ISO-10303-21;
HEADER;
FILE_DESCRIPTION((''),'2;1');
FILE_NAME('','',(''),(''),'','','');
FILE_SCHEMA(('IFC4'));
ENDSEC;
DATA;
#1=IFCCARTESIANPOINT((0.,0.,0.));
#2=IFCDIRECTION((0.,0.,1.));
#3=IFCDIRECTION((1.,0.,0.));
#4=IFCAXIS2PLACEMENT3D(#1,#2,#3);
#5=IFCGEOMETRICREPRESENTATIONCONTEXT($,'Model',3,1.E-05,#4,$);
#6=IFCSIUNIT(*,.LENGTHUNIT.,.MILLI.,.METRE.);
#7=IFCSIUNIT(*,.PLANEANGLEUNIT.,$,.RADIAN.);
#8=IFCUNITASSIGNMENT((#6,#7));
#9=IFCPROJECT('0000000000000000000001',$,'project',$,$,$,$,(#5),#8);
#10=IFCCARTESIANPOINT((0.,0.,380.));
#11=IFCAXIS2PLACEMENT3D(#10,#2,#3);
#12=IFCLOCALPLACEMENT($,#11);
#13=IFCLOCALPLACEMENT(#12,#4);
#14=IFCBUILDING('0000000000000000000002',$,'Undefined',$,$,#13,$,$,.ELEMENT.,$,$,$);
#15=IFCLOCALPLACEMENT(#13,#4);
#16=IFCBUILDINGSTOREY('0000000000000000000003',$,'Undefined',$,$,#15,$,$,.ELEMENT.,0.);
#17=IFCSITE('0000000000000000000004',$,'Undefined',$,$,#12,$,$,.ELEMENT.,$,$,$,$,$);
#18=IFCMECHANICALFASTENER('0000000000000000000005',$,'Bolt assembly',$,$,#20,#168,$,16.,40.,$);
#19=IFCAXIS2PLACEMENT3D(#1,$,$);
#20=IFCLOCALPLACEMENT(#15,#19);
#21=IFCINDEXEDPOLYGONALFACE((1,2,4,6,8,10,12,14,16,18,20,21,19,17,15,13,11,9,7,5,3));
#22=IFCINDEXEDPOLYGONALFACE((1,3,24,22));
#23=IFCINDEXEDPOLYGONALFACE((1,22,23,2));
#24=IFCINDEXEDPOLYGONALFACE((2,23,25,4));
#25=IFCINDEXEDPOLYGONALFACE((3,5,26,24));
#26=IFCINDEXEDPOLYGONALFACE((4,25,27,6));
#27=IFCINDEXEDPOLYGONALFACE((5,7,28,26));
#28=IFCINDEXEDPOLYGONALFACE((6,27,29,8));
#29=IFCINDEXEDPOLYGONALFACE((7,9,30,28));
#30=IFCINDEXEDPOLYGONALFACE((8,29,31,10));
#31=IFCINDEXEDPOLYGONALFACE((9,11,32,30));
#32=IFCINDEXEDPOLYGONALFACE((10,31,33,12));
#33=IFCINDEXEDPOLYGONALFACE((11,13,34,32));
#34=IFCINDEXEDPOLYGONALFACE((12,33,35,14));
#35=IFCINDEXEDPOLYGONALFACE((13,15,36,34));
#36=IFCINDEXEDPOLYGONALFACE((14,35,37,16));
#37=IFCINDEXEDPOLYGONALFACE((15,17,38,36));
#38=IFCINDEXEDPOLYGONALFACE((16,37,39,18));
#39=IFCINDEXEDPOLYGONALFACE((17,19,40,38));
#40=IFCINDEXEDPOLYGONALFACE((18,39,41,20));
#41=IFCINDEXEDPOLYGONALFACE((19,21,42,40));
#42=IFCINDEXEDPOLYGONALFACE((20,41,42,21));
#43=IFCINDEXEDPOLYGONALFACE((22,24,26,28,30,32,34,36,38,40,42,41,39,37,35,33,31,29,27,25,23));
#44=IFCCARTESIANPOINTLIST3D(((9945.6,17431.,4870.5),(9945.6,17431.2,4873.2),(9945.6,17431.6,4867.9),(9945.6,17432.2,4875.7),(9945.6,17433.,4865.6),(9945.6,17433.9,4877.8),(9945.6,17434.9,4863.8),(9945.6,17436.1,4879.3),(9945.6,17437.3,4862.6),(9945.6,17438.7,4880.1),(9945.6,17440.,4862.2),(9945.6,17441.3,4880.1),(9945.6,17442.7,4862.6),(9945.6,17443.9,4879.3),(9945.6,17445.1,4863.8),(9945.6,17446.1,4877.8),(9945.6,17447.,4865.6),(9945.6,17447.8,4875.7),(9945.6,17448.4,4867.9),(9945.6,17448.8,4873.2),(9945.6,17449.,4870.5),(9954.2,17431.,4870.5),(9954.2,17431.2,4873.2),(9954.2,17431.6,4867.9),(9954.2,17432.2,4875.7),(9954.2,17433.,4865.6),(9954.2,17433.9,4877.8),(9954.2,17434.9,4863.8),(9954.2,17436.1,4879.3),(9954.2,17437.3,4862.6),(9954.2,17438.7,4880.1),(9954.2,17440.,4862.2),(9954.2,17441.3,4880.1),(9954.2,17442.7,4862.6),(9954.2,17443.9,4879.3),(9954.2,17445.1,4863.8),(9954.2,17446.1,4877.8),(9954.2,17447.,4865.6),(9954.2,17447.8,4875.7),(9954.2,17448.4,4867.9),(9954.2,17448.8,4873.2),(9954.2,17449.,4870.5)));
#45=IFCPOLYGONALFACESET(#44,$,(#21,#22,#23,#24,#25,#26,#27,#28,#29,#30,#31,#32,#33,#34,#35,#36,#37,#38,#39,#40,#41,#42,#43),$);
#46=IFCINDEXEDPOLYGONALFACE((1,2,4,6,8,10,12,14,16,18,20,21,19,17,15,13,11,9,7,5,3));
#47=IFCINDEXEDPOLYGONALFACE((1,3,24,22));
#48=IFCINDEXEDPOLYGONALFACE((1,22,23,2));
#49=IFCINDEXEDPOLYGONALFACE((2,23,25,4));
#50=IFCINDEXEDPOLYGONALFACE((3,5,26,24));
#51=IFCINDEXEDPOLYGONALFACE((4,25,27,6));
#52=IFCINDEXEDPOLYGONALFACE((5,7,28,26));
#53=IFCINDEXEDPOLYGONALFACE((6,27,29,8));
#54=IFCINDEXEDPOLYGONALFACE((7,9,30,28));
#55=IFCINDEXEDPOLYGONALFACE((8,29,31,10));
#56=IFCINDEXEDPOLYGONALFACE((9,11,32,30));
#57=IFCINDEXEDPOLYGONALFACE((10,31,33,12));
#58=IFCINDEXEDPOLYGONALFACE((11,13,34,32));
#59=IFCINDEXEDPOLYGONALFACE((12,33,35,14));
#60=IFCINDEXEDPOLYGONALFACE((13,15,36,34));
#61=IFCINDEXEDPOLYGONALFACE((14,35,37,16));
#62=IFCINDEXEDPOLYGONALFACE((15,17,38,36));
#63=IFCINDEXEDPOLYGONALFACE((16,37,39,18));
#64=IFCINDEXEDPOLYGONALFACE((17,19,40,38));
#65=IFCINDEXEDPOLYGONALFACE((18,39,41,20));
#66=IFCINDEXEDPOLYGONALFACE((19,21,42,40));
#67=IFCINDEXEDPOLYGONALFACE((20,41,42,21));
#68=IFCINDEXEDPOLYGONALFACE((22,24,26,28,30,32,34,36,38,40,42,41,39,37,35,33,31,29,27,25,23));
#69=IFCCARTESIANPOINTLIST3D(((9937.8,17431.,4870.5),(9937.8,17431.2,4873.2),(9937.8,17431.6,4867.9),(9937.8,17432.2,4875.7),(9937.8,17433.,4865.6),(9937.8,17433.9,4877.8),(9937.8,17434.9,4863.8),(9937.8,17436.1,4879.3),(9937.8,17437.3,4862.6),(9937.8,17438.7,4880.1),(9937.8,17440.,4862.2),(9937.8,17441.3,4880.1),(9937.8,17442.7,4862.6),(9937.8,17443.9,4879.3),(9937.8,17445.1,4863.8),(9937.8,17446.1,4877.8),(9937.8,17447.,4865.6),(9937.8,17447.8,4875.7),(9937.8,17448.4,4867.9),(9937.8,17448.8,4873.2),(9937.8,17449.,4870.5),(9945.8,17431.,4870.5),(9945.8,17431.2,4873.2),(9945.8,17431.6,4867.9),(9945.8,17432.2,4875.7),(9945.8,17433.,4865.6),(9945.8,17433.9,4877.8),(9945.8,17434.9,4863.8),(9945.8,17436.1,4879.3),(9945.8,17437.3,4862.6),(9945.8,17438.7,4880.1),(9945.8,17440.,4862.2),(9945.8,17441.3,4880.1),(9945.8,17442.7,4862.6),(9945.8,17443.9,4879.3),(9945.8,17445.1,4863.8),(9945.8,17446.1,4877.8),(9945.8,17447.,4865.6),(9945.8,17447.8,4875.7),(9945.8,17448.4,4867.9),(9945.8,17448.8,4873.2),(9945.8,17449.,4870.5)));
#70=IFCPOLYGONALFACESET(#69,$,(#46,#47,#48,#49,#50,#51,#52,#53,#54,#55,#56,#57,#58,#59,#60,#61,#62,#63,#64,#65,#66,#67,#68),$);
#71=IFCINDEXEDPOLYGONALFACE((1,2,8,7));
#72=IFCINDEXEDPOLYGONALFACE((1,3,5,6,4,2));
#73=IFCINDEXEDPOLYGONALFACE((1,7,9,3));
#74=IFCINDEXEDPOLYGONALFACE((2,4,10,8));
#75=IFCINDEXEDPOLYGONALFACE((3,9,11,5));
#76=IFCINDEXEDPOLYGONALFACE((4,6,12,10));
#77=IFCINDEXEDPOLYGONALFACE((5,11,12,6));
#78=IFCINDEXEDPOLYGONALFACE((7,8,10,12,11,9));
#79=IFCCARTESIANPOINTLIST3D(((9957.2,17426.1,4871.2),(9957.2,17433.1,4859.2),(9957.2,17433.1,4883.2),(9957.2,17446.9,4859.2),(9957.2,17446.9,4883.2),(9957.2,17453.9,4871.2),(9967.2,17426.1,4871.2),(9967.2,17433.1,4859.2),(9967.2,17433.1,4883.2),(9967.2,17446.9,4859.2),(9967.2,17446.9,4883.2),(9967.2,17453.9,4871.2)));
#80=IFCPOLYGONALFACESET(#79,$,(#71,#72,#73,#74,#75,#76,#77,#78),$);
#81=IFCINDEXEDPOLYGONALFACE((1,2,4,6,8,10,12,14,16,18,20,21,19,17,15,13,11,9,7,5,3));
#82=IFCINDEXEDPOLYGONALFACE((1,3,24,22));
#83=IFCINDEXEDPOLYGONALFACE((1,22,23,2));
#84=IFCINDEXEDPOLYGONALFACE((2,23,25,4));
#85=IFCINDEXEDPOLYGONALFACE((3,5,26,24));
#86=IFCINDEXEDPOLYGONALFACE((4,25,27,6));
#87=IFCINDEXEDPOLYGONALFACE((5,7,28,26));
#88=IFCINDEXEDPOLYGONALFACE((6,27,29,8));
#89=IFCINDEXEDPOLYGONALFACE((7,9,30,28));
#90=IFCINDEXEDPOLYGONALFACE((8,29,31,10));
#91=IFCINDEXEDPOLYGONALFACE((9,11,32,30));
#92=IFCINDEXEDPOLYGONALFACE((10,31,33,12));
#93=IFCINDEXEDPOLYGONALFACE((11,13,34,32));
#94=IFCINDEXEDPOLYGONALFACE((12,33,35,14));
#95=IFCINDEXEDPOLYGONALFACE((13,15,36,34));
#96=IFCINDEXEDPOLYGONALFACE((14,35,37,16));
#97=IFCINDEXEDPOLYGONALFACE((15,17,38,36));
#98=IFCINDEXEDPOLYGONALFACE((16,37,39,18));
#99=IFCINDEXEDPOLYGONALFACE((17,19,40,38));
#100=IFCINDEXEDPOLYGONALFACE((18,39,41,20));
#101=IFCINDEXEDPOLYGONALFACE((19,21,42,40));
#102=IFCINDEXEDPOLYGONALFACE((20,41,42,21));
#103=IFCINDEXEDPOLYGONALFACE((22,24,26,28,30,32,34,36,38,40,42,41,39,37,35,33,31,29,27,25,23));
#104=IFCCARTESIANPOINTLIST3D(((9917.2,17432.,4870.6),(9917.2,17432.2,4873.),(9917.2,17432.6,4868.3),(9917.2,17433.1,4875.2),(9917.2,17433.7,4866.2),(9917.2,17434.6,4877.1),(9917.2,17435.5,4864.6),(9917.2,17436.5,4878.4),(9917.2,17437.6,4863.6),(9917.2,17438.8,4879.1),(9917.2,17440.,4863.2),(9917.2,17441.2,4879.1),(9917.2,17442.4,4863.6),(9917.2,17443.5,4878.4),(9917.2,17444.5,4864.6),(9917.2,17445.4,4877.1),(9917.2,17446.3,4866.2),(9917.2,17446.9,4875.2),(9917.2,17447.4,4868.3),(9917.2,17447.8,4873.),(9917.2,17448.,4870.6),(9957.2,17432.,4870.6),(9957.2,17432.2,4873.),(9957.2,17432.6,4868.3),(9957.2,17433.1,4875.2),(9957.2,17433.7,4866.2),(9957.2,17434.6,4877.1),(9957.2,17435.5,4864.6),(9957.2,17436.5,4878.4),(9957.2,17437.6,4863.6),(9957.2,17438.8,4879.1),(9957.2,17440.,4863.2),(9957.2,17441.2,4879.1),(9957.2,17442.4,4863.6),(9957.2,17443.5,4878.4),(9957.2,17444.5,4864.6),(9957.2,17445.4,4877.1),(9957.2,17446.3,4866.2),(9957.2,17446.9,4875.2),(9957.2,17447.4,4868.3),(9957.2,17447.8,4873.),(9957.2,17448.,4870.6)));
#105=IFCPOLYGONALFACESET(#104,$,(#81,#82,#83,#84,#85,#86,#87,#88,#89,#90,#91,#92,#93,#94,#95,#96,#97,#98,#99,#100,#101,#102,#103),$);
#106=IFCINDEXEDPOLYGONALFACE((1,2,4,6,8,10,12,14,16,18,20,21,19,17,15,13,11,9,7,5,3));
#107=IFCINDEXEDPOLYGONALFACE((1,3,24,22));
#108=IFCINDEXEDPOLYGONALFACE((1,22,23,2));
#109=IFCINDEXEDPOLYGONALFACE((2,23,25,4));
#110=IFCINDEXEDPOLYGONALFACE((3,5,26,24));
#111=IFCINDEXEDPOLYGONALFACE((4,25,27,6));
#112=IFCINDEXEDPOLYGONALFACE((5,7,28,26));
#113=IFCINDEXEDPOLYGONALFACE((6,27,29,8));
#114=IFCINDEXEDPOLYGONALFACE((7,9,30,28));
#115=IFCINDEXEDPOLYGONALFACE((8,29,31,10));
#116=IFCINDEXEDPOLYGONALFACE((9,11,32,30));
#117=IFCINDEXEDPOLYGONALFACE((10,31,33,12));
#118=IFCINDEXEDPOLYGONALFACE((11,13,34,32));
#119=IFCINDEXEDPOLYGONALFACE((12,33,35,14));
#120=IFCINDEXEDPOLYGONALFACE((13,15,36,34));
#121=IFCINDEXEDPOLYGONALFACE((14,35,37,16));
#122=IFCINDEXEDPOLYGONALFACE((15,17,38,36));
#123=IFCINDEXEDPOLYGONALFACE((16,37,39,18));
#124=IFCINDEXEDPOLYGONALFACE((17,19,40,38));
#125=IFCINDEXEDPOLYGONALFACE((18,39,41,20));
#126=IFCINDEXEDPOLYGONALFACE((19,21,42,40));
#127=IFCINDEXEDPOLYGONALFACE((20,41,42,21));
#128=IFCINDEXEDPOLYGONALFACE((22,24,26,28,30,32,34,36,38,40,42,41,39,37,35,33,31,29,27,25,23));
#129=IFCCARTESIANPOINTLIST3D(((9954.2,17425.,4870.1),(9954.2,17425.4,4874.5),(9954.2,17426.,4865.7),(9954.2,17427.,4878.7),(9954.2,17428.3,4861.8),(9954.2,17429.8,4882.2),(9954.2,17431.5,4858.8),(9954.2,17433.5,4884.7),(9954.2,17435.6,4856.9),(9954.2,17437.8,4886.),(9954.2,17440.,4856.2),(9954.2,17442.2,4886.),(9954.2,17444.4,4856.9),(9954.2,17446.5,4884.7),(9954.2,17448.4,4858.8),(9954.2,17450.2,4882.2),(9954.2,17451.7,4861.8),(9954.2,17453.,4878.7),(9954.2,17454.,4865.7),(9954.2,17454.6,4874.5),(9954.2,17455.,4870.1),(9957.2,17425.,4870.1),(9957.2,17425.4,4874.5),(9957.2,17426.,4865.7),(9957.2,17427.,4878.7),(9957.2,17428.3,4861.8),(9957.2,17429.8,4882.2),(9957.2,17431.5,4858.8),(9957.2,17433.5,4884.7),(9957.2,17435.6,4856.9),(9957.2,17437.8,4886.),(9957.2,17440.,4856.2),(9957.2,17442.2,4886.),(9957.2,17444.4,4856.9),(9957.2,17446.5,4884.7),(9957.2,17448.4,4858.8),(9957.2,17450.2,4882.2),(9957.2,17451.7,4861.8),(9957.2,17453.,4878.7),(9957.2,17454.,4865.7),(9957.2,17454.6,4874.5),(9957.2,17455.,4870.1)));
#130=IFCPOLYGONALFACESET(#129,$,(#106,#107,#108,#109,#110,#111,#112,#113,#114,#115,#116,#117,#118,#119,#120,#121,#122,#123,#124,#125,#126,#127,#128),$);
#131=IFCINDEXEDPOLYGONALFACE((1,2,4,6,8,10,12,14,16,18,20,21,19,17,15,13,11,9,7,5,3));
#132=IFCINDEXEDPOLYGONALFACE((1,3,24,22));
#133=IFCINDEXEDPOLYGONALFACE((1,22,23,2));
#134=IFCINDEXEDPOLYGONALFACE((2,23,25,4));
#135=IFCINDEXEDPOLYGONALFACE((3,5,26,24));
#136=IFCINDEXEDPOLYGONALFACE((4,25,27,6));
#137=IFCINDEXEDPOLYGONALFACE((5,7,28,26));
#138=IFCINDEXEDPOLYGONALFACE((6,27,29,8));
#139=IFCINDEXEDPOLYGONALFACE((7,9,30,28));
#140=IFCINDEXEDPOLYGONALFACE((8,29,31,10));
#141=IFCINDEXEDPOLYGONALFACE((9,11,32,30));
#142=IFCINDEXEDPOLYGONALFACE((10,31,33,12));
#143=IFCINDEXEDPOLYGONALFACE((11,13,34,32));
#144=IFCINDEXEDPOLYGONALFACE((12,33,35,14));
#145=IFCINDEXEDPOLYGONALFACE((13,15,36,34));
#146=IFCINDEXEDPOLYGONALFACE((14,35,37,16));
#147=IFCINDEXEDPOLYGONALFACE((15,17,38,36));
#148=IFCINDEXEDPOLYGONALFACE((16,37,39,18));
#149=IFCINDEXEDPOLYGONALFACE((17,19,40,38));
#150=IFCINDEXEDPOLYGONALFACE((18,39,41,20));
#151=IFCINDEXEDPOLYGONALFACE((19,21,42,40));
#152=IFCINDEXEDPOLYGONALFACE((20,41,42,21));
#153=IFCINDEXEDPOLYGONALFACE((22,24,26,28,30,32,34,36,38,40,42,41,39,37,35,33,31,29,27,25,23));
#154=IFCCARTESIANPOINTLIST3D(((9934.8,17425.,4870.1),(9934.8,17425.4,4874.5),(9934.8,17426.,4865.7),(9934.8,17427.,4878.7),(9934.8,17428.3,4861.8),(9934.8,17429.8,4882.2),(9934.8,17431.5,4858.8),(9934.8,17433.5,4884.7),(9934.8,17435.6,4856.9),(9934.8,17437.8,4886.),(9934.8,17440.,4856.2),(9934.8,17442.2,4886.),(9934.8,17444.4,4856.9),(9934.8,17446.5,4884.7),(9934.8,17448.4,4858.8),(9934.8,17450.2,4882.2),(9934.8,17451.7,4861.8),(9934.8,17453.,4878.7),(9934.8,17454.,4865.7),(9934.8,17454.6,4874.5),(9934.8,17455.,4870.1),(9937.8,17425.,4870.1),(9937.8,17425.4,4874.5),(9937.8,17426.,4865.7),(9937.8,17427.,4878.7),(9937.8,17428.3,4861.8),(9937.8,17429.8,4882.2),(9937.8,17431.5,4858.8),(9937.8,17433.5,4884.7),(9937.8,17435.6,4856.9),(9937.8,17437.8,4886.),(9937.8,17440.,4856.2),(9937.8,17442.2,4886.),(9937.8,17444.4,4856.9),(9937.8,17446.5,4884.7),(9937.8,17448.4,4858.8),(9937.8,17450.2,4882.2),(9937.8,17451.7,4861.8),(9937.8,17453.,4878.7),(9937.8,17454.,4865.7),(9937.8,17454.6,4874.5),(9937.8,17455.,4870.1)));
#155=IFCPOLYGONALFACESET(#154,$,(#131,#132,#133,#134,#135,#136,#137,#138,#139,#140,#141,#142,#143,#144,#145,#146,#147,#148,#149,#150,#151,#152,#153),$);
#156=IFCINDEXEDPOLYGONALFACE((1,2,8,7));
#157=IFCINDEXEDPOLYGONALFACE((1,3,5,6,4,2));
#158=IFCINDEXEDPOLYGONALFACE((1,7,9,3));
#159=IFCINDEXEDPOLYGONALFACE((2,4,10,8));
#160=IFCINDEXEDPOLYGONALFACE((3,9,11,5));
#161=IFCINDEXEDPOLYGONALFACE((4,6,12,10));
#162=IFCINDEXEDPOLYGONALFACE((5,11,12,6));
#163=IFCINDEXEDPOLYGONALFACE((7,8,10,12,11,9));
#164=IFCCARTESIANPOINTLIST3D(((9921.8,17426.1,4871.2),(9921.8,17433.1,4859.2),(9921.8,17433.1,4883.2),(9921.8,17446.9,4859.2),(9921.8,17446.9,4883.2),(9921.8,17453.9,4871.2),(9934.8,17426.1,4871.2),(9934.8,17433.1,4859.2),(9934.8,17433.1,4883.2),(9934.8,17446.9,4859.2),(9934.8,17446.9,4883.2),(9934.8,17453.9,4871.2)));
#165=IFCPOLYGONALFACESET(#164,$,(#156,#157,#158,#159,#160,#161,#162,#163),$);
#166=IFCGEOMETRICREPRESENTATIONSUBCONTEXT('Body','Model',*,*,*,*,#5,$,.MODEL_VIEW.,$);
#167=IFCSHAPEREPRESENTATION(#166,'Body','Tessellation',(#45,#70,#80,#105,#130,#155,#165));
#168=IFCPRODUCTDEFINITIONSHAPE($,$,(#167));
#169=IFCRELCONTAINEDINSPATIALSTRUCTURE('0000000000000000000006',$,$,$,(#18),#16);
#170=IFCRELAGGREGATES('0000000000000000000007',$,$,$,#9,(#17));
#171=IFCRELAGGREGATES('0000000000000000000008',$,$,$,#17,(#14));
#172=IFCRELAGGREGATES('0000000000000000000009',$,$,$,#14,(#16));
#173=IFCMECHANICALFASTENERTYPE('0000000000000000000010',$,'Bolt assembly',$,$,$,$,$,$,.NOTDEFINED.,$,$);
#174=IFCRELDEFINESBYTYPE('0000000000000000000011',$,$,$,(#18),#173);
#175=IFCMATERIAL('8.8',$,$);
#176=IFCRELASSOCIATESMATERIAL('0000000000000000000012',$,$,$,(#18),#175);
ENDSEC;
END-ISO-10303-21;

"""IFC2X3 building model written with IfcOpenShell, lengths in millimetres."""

from ifc_helpers import new_model, si_unit, frame, origin_with_axes, origin_2d_with_axis, place, context, subcontext, project, spatial, polyline, circle, outline, extrude, source, transform, mapped, material, type_object, element, save


model = new_model("IFC2X3")

# Units and contexts
model_context = context("Model", 3, precision=1e-05, world=origin_with_axes())
body_context = subcontext(model_context, "Body", "Model", "MODEL_VIEW")
ifc_project = project(units=[si_unit("LENGTHUNIT", "METRE", prefix="MILLI"), si_unit("PLANEANGLEUNIT", "RADIAN")], contexts=[model_context])

# Site, building, storey
site_placement = place(None, frame((0.0, 0.0, 380.0), z_axis=(0.0, 0.0, 1.0), x_axis=(1.0, 0.0, 0.0)))
site = spatial("IfcSite", under=ifc_project, at=site_placement, Name="Undefined", CompositionType="ELEMENT")
building_placement = place(site_placement, origin_with_axes())
building = spatial("IfcBuilding", under=site, at=building_placement, Name="Undefined", CompositionType="ELEMENT")
storey_placement = place(building_placement, origin_with_axes())
storey = spatial("IfcBuildingStorey", under=building, at=storey_placement, Name="Undefined", CompositionType="ELEMENT", Elevation=0.0)

# Mechanical fastener
ifc_material_1 = material(Name="8.8")
mechanical_fastener_type = type_object("IfcMechanicalFastenerType", Name="Bolt assembly")
shared_shape_1 = source(origin_with_axes(), body_context, "Body", "SweptSolid", [
    extrude(circle(Radius=9.0, at=origin_2d_with_axis()), frame((0.0, -8.4, 0.0), z_axis=(0.0, 1.0, 0.0), x_axis=(1.0, 0.0, 0.0)), (0.0, 0.0, 1.0), 8.5),
    extrude(circle(Radius=9.0, at=origin_2d_with_axis()), frame((0.0, -0.1, 0.0), z_axis=(0.0, 1.0, 0.0), x_axis=(1.0, 0.0, 0.0)), (0.0, 0.0, 1.0), 8.1),
    extrude(outline(polyline([(12.0, -6.9), (12.0, 6.9), (0.0, 13.9), (-12.0, 6.9), (-12.0, -6.9), (0.0, -13.9), (12.0, -6.9)])), frame((0.0, -21.5, 0.0), z_axis=(0.0, 1.0, 0.0), x_axis=(1.0, 0.0, 0.0)), (0.0, 0.0, 1.0), 10.0),
    extrude(circle(Radius=8.0, at=origin_2d_with_axis()), frame((0.0, -11.5, 0.0), z_axis=(0.0, 1.0, 0.0), x_axis=(1.0, 0.0, 0.0)), (0.0, 0.0, 1.0), 40.0),
    extrude(circle(Radius=15.0, at=origin_2d_with_axis()), frame((0.0, -11.5, 0.0), z_axis=(0.0, 1.0, 0.0), x_axis=(1.0, 0.0, 0.0)), (0.0, 0.0, 1.0), 3.0),
    extrude(circle(Radius=15.0, at=origin_2d_with_axis()), frame((0.0, 8.0, 0.0), z_axis=(0.0, 1.0, 0.0), x_axis=(1.0, 0.0, 0.0)), (0.0, 0.0, 1.0), 3.0),
    extrude(outline(polyline([(12.0, -6.9), (12.0, 6.9), (0.0, 13.9), (-12.0, 6.9), (-12.0, -6.9), (0.0, -13.9), (12.0, -6.9)])), frame((0.0, 11.0, 0.0), z_axis=(0.0, 1.0, 0.0), x_axis=(1.0, 0.0, 0.0)), (0.0, 0.0, 1.0), 13.0),
])
for number, where, z_axis, x_axis, name in (
    (1, (9945.8, 17402.5, 4951.2), (0.0, 1.0, 0.0), (0.0, 0.0, -1.0), "Bolt assembly"),
):
    element("IfcMechanicalFastener", number, at=place(storey_placement, frame(where, z_axis=z_axis, x_axis=x_axis)), inside=storey, type_object=mechanical_fastener_type, material=ifc_material_1, Name=name, NominalDiameter=16.0, NominalLength=40.0, context=body_context, shape_type="MappedRepresentation", body=[
        mapped(shared_shape_1, transform((80.0, 0.0, 37.5))),
    ])

save(model, "model.ifc")
